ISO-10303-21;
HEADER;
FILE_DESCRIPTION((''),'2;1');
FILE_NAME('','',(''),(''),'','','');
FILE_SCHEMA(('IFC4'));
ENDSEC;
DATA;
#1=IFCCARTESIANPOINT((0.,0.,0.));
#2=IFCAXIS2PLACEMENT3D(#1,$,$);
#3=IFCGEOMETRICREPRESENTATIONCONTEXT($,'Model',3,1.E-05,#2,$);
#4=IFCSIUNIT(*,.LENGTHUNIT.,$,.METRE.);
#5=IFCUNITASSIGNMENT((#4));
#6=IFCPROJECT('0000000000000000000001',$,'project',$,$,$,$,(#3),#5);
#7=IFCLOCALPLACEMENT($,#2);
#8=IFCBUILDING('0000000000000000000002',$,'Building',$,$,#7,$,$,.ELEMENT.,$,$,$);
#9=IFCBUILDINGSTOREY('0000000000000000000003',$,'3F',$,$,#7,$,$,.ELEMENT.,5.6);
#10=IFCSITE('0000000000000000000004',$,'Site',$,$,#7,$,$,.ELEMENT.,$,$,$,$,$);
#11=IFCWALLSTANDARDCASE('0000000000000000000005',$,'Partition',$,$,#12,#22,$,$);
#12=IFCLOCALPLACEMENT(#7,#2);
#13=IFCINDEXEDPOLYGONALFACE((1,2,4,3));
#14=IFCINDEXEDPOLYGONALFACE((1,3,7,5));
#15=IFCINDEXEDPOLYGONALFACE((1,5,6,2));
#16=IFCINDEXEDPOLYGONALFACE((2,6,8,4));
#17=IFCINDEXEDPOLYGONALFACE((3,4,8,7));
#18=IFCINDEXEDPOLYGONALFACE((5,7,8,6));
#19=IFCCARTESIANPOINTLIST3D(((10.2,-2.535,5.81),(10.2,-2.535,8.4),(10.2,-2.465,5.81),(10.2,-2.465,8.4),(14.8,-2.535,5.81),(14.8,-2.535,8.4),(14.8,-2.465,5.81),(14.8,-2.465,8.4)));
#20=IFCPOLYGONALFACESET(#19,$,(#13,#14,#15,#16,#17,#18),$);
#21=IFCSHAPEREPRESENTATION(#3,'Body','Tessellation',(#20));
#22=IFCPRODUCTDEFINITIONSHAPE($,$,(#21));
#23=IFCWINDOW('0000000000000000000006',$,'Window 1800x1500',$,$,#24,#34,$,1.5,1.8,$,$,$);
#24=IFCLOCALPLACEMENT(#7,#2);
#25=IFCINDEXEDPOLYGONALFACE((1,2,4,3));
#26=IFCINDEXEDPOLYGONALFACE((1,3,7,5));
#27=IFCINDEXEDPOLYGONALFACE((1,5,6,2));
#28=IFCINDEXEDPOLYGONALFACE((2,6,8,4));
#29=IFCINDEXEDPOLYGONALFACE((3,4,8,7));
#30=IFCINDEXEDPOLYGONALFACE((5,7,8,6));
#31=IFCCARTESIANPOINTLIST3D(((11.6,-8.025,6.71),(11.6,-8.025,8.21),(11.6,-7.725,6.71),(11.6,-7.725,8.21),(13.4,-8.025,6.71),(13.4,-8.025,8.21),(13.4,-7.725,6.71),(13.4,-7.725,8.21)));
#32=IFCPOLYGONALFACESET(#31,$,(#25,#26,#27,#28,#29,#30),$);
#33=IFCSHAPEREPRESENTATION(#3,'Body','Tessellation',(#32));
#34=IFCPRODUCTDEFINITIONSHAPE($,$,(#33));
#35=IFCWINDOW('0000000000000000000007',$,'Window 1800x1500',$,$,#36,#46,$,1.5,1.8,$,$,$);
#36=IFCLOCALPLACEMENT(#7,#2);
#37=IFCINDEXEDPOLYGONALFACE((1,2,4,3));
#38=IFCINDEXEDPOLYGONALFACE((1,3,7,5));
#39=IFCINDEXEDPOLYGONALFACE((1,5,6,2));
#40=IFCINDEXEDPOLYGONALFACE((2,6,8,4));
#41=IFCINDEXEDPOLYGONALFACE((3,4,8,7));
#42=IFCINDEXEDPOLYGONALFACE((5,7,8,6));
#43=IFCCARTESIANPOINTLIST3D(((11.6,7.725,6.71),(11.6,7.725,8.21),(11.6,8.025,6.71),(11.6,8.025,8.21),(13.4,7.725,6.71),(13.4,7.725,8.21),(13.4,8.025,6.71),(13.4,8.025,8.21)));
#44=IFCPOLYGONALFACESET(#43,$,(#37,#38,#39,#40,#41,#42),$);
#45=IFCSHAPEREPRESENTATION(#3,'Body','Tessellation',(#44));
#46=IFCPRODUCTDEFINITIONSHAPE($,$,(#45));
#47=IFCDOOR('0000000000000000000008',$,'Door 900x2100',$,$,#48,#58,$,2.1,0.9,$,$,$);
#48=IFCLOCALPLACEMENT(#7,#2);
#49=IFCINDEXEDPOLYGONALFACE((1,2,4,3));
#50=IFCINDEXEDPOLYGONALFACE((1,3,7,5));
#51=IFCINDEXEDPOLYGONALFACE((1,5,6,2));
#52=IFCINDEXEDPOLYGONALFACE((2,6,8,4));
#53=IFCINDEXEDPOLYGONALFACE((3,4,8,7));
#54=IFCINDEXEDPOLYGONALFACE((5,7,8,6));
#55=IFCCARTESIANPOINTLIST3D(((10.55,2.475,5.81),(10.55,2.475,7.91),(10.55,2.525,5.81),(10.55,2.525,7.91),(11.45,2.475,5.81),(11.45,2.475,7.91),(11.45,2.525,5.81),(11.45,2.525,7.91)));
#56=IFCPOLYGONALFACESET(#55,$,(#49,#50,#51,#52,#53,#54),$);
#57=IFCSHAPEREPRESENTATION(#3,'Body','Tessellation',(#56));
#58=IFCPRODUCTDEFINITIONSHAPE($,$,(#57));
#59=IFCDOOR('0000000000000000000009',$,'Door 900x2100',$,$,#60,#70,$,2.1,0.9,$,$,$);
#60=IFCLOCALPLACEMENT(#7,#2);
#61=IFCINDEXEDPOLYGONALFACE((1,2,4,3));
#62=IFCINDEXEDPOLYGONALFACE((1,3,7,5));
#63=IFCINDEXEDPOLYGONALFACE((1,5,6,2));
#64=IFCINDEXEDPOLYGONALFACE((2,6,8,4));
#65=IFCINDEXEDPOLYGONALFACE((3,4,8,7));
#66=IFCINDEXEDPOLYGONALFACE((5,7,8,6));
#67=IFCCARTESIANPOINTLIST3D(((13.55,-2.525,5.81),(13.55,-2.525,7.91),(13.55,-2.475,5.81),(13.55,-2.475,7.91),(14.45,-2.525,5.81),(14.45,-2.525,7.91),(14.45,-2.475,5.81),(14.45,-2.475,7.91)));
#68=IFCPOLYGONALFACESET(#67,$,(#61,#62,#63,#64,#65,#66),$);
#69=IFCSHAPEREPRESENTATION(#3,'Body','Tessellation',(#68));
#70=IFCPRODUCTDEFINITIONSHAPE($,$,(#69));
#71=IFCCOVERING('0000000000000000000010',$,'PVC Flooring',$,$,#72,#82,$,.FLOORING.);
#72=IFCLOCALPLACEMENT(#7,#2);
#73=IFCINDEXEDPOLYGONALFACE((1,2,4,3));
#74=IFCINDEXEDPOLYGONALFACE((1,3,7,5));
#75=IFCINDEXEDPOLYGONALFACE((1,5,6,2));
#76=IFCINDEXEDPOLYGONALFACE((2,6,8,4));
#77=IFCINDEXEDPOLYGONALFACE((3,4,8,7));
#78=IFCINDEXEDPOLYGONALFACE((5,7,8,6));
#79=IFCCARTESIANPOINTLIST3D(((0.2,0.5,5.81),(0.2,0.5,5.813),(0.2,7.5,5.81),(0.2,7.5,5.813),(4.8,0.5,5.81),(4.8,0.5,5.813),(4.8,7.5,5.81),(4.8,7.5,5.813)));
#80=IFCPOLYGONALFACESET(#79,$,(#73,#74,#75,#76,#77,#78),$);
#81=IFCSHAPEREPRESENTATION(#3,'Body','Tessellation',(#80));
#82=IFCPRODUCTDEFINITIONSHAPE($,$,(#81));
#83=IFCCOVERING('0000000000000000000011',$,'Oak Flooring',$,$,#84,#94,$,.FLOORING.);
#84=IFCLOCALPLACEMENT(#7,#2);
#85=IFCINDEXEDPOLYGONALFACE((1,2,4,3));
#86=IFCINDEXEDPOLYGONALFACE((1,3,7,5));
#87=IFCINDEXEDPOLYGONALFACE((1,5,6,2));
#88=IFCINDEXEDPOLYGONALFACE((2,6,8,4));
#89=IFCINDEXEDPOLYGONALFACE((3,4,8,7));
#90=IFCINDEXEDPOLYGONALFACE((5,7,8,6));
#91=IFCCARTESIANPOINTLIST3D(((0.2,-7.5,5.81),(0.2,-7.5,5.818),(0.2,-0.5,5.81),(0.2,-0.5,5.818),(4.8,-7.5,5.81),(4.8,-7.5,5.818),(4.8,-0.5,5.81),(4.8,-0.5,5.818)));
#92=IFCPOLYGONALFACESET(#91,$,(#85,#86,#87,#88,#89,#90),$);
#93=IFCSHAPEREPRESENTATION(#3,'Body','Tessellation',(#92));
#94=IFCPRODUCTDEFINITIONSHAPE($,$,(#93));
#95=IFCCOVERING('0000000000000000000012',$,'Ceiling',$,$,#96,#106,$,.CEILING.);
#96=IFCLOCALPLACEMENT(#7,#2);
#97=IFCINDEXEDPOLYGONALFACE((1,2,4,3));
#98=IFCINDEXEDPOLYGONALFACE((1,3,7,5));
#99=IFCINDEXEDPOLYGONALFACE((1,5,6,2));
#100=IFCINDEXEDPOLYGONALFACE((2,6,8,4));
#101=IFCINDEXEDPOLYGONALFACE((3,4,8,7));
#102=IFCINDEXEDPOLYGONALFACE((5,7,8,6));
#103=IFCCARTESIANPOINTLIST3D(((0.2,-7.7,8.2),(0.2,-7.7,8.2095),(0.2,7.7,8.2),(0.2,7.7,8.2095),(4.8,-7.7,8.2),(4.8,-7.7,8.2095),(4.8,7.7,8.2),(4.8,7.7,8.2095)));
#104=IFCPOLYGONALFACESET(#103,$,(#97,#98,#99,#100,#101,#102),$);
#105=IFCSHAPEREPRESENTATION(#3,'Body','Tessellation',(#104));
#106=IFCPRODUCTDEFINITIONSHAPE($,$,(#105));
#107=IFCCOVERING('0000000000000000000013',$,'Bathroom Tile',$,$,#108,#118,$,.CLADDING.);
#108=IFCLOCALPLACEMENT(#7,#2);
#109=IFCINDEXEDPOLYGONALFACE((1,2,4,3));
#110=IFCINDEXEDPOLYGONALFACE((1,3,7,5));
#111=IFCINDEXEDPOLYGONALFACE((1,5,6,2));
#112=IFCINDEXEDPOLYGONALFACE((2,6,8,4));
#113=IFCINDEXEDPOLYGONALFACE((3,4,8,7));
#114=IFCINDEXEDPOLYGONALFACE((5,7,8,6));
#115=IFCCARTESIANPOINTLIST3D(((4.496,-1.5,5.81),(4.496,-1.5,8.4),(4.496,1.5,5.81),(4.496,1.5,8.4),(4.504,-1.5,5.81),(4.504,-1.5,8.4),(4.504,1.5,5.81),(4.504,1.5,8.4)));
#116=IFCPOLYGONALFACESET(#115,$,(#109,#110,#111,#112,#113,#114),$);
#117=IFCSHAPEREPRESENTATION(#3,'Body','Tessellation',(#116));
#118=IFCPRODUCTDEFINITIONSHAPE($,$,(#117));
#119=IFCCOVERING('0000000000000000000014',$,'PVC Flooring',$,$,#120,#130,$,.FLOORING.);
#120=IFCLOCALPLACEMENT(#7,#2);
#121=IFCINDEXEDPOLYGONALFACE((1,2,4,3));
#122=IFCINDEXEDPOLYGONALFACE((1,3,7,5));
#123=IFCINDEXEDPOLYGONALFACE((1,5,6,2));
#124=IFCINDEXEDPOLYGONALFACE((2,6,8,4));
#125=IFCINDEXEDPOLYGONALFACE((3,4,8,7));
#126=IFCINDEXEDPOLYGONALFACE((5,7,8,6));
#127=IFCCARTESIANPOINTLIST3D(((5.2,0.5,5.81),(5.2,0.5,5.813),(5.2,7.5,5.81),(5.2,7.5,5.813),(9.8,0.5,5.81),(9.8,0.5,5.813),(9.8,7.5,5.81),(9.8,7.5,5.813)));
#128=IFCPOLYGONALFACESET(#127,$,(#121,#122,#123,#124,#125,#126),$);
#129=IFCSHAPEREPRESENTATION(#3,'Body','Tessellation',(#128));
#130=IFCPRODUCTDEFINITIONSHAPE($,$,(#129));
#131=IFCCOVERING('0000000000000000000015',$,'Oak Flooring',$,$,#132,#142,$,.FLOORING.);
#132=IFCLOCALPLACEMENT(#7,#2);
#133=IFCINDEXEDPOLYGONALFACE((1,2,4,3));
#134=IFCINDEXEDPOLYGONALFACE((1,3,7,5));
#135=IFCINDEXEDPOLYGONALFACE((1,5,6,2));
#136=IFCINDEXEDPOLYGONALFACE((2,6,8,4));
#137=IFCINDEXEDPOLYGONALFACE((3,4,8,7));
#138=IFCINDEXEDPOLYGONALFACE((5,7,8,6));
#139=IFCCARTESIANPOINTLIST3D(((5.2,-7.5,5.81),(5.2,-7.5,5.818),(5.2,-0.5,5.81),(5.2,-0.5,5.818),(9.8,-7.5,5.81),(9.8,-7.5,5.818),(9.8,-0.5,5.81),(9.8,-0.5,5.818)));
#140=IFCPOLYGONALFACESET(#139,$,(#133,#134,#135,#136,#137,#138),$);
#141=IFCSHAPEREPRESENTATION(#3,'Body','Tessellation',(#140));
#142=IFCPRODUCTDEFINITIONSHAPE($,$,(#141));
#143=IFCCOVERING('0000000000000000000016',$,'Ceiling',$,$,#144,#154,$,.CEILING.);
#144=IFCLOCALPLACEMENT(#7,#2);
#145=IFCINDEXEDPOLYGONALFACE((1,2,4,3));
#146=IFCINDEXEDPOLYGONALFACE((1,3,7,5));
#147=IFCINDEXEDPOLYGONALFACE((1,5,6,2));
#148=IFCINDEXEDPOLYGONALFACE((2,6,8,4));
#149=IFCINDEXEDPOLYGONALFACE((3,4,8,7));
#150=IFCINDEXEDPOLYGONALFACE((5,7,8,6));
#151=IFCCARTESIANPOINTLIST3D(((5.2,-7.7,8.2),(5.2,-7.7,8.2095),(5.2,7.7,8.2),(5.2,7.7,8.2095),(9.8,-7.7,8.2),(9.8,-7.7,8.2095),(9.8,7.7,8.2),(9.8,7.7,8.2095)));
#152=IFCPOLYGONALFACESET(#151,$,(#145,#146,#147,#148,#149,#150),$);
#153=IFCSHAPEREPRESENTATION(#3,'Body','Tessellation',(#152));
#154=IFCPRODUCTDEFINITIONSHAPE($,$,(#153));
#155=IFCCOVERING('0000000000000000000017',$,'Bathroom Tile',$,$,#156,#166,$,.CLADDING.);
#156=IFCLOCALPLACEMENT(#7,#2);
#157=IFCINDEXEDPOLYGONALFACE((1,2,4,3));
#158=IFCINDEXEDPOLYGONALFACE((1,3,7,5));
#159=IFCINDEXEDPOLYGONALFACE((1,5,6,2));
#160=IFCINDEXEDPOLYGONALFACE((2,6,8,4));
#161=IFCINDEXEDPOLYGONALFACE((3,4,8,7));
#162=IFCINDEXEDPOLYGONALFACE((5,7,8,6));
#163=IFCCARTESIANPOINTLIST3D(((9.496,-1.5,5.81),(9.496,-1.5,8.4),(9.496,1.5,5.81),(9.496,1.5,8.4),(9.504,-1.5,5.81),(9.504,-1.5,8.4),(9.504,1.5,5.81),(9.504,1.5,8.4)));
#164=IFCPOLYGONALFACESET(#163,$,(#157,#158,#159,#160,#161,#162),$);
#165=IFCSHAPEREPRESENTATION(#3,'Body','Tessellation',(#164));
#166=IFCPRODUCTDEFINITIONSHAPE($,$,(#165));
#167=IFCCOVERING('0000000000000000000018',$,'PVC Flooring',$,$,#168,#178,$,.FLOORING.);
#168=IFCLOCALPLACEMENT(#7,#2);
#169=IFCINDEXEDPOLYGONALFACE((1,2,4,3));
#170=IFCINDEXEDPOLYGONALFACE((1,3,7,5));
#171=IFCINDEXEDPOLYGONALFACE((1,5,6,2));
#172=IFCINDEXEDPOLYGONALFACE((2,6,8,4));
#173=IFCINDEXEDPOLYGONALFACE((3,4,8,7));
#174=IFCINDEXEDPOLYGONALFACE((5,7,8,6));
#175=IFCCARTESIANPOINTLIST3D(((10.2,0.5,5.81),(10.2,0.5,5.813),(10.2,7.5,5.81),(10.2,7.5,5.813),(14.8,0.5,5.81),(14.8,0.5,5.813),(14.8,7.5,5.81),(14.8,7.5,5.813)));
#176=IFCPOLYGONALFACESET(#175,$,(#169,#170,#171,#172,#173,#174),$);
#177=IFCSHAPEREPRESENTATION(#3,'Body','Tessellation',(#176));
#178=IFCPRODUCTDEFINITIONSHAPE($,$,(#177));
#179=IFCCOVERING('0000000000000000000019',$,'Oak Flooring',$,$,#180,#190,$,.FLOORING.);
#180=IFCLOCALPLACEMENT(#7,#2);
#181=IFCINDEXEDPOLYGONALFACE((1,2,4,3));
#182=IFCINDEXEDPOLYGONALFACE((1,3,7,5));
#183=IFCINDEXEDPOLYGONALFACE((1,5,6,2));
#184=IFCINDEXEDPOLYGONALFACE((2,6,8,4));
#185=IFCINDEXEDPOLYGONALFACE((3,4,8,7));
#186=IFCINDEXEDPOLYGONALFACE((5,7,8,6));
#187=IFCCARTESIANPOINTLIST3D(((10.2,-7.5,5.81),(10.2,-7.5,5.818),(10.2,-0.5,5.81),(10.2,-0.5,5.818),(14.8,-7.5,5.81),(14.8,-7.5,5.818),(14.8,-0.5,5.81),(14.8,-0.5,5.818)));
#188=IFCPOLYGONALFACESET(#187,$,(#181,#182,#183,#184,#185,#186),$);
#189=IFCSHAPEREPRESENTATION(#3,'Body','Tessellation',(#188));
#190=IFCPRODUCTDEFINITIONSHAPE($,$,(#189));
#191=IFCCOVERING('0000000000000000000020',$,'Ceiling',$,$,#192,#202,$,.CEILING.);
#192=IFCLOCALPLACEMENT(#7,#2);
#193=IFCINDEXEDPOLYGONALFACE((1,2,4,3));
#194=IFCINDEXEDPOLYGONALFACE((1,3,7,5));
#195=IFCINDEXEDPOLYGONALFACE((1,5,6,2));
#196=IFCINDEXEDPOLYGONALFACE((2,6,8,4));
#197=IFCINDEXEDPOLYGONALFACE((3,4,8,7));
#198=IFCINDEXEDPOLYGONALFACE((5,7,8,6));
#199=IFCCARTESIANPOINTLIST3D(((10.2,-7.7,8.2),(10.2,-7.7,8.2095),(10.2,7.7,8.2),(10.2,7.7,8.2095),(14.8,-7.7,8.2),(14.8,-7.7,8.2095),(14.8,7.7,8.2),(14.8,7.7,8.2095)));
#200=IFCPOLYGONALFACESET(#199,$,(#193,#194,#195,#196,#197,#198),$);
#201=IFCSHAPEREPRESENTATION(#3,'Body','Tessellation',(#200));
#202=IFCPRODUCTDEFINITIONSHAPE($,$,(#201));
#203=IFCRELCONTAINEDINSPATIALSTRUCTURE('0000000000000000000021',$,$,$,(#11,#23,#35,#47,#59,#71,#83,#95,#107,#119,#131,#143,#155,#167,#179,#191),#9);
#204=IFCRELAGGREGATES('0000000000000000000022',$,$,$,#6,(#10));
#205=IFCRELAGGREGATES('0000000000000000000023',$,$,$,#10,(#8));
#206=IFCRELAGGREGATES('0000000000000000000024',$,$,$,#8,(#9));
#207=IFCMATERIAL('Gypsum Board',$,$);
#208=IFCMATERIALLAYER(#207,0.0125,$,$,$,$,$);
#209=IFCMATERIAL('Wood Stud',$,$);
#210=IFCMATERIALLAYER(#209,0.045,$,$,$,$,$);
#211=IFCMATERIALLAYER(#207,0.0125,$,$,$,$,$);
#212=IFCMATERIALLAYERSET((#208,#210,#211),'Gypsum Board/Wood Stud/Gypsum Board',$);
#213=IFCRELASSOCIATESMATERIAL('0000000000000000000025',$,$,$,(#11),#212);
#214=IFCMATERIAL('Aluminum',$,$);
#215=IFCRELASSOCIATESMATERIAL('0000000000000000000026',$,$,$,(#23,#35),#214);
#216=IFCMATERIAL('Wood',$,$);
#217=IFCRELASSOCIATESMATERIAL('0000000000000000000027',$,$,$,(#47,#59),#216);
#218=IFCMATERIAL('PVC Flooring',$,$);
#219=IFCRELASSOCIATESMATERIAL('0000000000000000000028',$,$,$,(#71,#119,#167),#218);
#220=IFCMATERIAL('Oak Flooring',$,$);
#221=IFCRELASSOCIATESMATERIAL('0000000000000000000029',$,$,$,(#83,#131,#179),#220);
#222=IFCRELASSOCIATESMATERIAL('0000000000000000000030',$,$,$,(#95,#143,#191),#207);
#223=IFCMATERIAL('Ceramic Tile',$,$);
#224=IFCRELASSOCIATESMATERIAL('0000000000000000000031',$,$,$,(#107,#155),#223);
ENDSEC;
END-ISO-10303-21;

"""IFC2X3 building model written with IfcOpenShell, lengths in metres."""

from ifc_helpers import new_model, si_unit, frame, origin, origin_2d, place, context, project, spatial, rectangle, extrude, material, layer, layer_set, layer_usage, element, save


model = new_model("IFC2X3")

# Units and contexts
model_context = context("Model", 3, precision=1e-05, world=origin())
ifc_project = project(units=[si_unit("LENGTHUNIT", "METRE")], contexts=[model_context])

# Site, building, storey
placement = place(None, origin())
site = spatial("IfcSite", under=ifc_project, at=placement, Name="Site", CompositionType="ELEMENT")
building = spatial("IfcBuilding", under=site, at=placement, Name="Building", CompositionType="ELEMENT")
storey = spatial("IfcBuildingStorey", under=building, at=placement, Name="3F", CompositionType="ELEMENT", Elevation=5.6)

# Shared definitions
ifc_material_1 = material(Name="Gypsum Board")
ifc_layer_1 = layer(ifc_material_1, 0.0125)
ifc_material_2 = material(Name="Wood Stud")
ifc_layer_2 = layer(ifc_material_2, 0.045)
ifc_layer_3 = layer(ifc_material_1, 0.0125)
ifc_layer_set_1 = layer_set([ifc_layer_1, ifc_layer_2, ifc_layer_3], Name="Gypsum Board/Wood Stud/Gypsum Board")
ifc_layer_usage_1 = layer_usage(ifc_layer_set_1, "AXIS2", "POSITIVE", 0.0)

# Shared definitions
ifc_material_3 = material(Name="Aluminum")

# Shared definitions
ifc_material_4 = material(Name="Wood")

# Wall
for number, where, name in (
    (1, (12.5, -2.5, 5.81), "Partition"),
):
    element("IfcWallStandardCase", number, at=place(None, frame(where)), inside=storey, material=ifc_layer_usage_1, Name=name, context=model_context, shape_type="SweptSolid", body=[
        extrude(rectangle(XDim=4.6, YDim=0.07, at=origin_2d()), origin(), (0.0, 0.0, 1.0), 2.59),
    ])

# Windows
for number, where, name in (
    (2, (12.5, -7.875, 6.71), "Window 1800x1500"),
    (3, (12.5, 7.875, 6.71), "Window 1800x1500"),
):
    element("IfcWindow", number, at=place(None, frame(where)), inside=storey, material=ifc_material_3, Name=name, OverallHeight=1.5, OverallWidth=1.8, context=model_context, shape_type="SweptSolid", body=[
        extrude(rectangle(XDim=1.8, YDim=0.3, at=origin_2d()), origin(), (0.0, 0.0, 1.0), 1.5),
    ])

# Doors
for number, where, name in (
    (4, (11.0, 2.5, 5.81), "Door 900x2100"),
    (5, (14.0, -2.5, 5.81), "Door 900x2100"),
):
    element("IfcDoor", number, at=place(None, frame(where)), inside=storey, material=ifc_material_4, Name=name, OverallHeight=2.1, OverallWidth=0.9, context=model_context, shape_type="SweptSolid", body=[
        extrude(rectangle(XDim=0.9, YDim=0.05, at=origin_2d()), origin(), (0.0, 0.0, 1.0), 2.1),
    ])

# Coverings
ifc_material_5 = material(Name="PVC Flooring")
covering_1_placement = place(None, frame((2.5, 4.0, 5.81)))
element("IfcCovering", 6, at=covering_1_placement, inside=storey, material=ifc_material_5, Name="PVC Flooring", PredefinedType="FLOORING", context=model_context, shape_type="SweptSolid", body=[
    extrude(rectangle(XDim=4.6, YDim=7.0, at=origin_2d()), origin(), (0.0, 0.0, 1.0), 0.003),
])
ifc_material_6 = material(Name="Oak Flooring")
covering_2_placement = place(None, frame((2.5, -4.0, 5.81)))
element("IfcCovering", 7, at=covering_2_placement, inside=storey, material=ifc_material_6, Name="Oak Flooring", PredefinedType="FLOORING", context=model_context, shape_type="SweptSolid", body=[
    extrude(rectangle(XDim=4.6, YDim=7.0, at=origin_2d()), origin(), (0.0, 0.0, 1.0), 0.008),
])
covering_3_placement = place(None, frame((2.5, 0.0, 8.2)))
element("IfcCovering", 8, at=covering_3_placement, inside=storey, material=ifc_material_1, Name="Ceiling", PredefinedType="CEILING", context=model_context, shape_type="SweptSolid", body=[
    extrude(rectangle(XDim=4.6, YDim=15.4, at=origin_2d()), origin(), (0.0, 0.0, 1.0), 0.0095),
])
ifc_material_7 = material(Name="Ceramic Tile")
covering_4_placement = place(None, frame((4.5, 0.0, 5.81)))
element("IfcCovering", 9, at=covering_4_placement, inside=storey, material=ifc_material_7, Name="Bathroom Tile", PredefinedType="CLADDING", context=model_context, shape_type="SweptSolid", body=[
    extrude(rectangle(XDim=0.008, YDim=3.0, at=origin_2d()), origin(), (0.0, 0.0, 1.0), 2.59),
])
covering_5_placement = place(None, frame((7.5, 4.0, 5.81)))
element("IfcCovering", 10, at=covering_5_placement, inside=storey, material=ifc_material_5, Name="PVC Flooring", PredefinedType="FLOORING", context=model_context, shape_type="SweptSolid", body=[
    extrude(rectangle(XDim=4.6, YDim=7.0, at=origin_2d()), origin(), (0.0, 0.0, 1.0), 0.003),
])
covering_6_placement = place(None, frame((7.5, -4.0, 5.81)))
element("IfcCovering", 11, at=covering_6_placement, inside=storey, material=ifc_material_6, Name="Oak Flooring", PredefinedType="FLOORING", context=model_context, shape_type="SweptSolid", body=[
    extrude(rectangle(XDim=4.6, YDim=7.0, at=origin_2d()), origin(), (0.0, 0.0, 1.0), 0.008),
])
covering_7_placement = place(None, frame((7.5, 0.0, 8.2)))
element("IfcCovering", 12, at=covering_7_placement, inside=storey, material=ifc_material_1, Name="Ceiling", PredefinedType="CEILING", context=model_context, shape_type="SweptSolid", body=[
    extrude(rectangle(XDim=4.6, YDim=15.4, at=origin_2d()), origin(), (0.0, 0.0, 1.0), 0.0095),
])
covering_8_placement = place(None, frame((9.5, 0.0, 5.81)))
element("IfcCovering", 13, at=covering_8_placement, inside=storey, material=ifc_material_7, Name="Bathroom Tile", PredefinedType="CLADDING", context=model_context, shape_type="SweptSolid", body=[
    extrude(rectangle(XDim=0.008, YDim=3.0, at=origin_2d()), origin(), (0.0, 0.0, 1.0), 2.59),
])
covering_9_placement = place(None, frame((12.5, 4.0, 5.81)))
element("IfcCovering", 14, at=covering_9_placement, inside=storey, material=ifc_material_5, Name="PVC Flooring", PredefinedType="FLOORING", context=model_context, shape_type="SweptSolid", body=[
    extrude(rectangle(XDim=4.6, YDim=7.0, at=origin_2d()), origin(), (0.0, 0.0, 1.0), 0.003),
])
covering_10_placement = place(None, frame((12.5, -4.0, 5.81)))
element("IfcCovering", 15, at=covering_10_placement, inside=storey, material=ifc_material_6, Name="Oak Flooring", PredefinedType="FLOORING", context=model_context, shape_type="SweptSolid", body=[
    extrude(rectangle(XDim=4.6, YDim=7.0, at=origin_2d()), origin(), (0.0, 0.0, 1.0), 0.008),
])
covering_11_placement = place(None, frame((12.5, 0.0, 8.2)))
element("IfcCovering", 16, at=covering_11_placement, inside=storey, material=ifc_material_1, Name="Ceiling", PredefinedType="CEILING", context=model_context, shape_type="SweptSolid", body=[
    extrude(rectangle(XDim=4.6, YDim=15.4, at=origin_2d()), origin(), (0.0, 0.0, 1.0), 0.0095),
])

save(model, "model.ifc")
